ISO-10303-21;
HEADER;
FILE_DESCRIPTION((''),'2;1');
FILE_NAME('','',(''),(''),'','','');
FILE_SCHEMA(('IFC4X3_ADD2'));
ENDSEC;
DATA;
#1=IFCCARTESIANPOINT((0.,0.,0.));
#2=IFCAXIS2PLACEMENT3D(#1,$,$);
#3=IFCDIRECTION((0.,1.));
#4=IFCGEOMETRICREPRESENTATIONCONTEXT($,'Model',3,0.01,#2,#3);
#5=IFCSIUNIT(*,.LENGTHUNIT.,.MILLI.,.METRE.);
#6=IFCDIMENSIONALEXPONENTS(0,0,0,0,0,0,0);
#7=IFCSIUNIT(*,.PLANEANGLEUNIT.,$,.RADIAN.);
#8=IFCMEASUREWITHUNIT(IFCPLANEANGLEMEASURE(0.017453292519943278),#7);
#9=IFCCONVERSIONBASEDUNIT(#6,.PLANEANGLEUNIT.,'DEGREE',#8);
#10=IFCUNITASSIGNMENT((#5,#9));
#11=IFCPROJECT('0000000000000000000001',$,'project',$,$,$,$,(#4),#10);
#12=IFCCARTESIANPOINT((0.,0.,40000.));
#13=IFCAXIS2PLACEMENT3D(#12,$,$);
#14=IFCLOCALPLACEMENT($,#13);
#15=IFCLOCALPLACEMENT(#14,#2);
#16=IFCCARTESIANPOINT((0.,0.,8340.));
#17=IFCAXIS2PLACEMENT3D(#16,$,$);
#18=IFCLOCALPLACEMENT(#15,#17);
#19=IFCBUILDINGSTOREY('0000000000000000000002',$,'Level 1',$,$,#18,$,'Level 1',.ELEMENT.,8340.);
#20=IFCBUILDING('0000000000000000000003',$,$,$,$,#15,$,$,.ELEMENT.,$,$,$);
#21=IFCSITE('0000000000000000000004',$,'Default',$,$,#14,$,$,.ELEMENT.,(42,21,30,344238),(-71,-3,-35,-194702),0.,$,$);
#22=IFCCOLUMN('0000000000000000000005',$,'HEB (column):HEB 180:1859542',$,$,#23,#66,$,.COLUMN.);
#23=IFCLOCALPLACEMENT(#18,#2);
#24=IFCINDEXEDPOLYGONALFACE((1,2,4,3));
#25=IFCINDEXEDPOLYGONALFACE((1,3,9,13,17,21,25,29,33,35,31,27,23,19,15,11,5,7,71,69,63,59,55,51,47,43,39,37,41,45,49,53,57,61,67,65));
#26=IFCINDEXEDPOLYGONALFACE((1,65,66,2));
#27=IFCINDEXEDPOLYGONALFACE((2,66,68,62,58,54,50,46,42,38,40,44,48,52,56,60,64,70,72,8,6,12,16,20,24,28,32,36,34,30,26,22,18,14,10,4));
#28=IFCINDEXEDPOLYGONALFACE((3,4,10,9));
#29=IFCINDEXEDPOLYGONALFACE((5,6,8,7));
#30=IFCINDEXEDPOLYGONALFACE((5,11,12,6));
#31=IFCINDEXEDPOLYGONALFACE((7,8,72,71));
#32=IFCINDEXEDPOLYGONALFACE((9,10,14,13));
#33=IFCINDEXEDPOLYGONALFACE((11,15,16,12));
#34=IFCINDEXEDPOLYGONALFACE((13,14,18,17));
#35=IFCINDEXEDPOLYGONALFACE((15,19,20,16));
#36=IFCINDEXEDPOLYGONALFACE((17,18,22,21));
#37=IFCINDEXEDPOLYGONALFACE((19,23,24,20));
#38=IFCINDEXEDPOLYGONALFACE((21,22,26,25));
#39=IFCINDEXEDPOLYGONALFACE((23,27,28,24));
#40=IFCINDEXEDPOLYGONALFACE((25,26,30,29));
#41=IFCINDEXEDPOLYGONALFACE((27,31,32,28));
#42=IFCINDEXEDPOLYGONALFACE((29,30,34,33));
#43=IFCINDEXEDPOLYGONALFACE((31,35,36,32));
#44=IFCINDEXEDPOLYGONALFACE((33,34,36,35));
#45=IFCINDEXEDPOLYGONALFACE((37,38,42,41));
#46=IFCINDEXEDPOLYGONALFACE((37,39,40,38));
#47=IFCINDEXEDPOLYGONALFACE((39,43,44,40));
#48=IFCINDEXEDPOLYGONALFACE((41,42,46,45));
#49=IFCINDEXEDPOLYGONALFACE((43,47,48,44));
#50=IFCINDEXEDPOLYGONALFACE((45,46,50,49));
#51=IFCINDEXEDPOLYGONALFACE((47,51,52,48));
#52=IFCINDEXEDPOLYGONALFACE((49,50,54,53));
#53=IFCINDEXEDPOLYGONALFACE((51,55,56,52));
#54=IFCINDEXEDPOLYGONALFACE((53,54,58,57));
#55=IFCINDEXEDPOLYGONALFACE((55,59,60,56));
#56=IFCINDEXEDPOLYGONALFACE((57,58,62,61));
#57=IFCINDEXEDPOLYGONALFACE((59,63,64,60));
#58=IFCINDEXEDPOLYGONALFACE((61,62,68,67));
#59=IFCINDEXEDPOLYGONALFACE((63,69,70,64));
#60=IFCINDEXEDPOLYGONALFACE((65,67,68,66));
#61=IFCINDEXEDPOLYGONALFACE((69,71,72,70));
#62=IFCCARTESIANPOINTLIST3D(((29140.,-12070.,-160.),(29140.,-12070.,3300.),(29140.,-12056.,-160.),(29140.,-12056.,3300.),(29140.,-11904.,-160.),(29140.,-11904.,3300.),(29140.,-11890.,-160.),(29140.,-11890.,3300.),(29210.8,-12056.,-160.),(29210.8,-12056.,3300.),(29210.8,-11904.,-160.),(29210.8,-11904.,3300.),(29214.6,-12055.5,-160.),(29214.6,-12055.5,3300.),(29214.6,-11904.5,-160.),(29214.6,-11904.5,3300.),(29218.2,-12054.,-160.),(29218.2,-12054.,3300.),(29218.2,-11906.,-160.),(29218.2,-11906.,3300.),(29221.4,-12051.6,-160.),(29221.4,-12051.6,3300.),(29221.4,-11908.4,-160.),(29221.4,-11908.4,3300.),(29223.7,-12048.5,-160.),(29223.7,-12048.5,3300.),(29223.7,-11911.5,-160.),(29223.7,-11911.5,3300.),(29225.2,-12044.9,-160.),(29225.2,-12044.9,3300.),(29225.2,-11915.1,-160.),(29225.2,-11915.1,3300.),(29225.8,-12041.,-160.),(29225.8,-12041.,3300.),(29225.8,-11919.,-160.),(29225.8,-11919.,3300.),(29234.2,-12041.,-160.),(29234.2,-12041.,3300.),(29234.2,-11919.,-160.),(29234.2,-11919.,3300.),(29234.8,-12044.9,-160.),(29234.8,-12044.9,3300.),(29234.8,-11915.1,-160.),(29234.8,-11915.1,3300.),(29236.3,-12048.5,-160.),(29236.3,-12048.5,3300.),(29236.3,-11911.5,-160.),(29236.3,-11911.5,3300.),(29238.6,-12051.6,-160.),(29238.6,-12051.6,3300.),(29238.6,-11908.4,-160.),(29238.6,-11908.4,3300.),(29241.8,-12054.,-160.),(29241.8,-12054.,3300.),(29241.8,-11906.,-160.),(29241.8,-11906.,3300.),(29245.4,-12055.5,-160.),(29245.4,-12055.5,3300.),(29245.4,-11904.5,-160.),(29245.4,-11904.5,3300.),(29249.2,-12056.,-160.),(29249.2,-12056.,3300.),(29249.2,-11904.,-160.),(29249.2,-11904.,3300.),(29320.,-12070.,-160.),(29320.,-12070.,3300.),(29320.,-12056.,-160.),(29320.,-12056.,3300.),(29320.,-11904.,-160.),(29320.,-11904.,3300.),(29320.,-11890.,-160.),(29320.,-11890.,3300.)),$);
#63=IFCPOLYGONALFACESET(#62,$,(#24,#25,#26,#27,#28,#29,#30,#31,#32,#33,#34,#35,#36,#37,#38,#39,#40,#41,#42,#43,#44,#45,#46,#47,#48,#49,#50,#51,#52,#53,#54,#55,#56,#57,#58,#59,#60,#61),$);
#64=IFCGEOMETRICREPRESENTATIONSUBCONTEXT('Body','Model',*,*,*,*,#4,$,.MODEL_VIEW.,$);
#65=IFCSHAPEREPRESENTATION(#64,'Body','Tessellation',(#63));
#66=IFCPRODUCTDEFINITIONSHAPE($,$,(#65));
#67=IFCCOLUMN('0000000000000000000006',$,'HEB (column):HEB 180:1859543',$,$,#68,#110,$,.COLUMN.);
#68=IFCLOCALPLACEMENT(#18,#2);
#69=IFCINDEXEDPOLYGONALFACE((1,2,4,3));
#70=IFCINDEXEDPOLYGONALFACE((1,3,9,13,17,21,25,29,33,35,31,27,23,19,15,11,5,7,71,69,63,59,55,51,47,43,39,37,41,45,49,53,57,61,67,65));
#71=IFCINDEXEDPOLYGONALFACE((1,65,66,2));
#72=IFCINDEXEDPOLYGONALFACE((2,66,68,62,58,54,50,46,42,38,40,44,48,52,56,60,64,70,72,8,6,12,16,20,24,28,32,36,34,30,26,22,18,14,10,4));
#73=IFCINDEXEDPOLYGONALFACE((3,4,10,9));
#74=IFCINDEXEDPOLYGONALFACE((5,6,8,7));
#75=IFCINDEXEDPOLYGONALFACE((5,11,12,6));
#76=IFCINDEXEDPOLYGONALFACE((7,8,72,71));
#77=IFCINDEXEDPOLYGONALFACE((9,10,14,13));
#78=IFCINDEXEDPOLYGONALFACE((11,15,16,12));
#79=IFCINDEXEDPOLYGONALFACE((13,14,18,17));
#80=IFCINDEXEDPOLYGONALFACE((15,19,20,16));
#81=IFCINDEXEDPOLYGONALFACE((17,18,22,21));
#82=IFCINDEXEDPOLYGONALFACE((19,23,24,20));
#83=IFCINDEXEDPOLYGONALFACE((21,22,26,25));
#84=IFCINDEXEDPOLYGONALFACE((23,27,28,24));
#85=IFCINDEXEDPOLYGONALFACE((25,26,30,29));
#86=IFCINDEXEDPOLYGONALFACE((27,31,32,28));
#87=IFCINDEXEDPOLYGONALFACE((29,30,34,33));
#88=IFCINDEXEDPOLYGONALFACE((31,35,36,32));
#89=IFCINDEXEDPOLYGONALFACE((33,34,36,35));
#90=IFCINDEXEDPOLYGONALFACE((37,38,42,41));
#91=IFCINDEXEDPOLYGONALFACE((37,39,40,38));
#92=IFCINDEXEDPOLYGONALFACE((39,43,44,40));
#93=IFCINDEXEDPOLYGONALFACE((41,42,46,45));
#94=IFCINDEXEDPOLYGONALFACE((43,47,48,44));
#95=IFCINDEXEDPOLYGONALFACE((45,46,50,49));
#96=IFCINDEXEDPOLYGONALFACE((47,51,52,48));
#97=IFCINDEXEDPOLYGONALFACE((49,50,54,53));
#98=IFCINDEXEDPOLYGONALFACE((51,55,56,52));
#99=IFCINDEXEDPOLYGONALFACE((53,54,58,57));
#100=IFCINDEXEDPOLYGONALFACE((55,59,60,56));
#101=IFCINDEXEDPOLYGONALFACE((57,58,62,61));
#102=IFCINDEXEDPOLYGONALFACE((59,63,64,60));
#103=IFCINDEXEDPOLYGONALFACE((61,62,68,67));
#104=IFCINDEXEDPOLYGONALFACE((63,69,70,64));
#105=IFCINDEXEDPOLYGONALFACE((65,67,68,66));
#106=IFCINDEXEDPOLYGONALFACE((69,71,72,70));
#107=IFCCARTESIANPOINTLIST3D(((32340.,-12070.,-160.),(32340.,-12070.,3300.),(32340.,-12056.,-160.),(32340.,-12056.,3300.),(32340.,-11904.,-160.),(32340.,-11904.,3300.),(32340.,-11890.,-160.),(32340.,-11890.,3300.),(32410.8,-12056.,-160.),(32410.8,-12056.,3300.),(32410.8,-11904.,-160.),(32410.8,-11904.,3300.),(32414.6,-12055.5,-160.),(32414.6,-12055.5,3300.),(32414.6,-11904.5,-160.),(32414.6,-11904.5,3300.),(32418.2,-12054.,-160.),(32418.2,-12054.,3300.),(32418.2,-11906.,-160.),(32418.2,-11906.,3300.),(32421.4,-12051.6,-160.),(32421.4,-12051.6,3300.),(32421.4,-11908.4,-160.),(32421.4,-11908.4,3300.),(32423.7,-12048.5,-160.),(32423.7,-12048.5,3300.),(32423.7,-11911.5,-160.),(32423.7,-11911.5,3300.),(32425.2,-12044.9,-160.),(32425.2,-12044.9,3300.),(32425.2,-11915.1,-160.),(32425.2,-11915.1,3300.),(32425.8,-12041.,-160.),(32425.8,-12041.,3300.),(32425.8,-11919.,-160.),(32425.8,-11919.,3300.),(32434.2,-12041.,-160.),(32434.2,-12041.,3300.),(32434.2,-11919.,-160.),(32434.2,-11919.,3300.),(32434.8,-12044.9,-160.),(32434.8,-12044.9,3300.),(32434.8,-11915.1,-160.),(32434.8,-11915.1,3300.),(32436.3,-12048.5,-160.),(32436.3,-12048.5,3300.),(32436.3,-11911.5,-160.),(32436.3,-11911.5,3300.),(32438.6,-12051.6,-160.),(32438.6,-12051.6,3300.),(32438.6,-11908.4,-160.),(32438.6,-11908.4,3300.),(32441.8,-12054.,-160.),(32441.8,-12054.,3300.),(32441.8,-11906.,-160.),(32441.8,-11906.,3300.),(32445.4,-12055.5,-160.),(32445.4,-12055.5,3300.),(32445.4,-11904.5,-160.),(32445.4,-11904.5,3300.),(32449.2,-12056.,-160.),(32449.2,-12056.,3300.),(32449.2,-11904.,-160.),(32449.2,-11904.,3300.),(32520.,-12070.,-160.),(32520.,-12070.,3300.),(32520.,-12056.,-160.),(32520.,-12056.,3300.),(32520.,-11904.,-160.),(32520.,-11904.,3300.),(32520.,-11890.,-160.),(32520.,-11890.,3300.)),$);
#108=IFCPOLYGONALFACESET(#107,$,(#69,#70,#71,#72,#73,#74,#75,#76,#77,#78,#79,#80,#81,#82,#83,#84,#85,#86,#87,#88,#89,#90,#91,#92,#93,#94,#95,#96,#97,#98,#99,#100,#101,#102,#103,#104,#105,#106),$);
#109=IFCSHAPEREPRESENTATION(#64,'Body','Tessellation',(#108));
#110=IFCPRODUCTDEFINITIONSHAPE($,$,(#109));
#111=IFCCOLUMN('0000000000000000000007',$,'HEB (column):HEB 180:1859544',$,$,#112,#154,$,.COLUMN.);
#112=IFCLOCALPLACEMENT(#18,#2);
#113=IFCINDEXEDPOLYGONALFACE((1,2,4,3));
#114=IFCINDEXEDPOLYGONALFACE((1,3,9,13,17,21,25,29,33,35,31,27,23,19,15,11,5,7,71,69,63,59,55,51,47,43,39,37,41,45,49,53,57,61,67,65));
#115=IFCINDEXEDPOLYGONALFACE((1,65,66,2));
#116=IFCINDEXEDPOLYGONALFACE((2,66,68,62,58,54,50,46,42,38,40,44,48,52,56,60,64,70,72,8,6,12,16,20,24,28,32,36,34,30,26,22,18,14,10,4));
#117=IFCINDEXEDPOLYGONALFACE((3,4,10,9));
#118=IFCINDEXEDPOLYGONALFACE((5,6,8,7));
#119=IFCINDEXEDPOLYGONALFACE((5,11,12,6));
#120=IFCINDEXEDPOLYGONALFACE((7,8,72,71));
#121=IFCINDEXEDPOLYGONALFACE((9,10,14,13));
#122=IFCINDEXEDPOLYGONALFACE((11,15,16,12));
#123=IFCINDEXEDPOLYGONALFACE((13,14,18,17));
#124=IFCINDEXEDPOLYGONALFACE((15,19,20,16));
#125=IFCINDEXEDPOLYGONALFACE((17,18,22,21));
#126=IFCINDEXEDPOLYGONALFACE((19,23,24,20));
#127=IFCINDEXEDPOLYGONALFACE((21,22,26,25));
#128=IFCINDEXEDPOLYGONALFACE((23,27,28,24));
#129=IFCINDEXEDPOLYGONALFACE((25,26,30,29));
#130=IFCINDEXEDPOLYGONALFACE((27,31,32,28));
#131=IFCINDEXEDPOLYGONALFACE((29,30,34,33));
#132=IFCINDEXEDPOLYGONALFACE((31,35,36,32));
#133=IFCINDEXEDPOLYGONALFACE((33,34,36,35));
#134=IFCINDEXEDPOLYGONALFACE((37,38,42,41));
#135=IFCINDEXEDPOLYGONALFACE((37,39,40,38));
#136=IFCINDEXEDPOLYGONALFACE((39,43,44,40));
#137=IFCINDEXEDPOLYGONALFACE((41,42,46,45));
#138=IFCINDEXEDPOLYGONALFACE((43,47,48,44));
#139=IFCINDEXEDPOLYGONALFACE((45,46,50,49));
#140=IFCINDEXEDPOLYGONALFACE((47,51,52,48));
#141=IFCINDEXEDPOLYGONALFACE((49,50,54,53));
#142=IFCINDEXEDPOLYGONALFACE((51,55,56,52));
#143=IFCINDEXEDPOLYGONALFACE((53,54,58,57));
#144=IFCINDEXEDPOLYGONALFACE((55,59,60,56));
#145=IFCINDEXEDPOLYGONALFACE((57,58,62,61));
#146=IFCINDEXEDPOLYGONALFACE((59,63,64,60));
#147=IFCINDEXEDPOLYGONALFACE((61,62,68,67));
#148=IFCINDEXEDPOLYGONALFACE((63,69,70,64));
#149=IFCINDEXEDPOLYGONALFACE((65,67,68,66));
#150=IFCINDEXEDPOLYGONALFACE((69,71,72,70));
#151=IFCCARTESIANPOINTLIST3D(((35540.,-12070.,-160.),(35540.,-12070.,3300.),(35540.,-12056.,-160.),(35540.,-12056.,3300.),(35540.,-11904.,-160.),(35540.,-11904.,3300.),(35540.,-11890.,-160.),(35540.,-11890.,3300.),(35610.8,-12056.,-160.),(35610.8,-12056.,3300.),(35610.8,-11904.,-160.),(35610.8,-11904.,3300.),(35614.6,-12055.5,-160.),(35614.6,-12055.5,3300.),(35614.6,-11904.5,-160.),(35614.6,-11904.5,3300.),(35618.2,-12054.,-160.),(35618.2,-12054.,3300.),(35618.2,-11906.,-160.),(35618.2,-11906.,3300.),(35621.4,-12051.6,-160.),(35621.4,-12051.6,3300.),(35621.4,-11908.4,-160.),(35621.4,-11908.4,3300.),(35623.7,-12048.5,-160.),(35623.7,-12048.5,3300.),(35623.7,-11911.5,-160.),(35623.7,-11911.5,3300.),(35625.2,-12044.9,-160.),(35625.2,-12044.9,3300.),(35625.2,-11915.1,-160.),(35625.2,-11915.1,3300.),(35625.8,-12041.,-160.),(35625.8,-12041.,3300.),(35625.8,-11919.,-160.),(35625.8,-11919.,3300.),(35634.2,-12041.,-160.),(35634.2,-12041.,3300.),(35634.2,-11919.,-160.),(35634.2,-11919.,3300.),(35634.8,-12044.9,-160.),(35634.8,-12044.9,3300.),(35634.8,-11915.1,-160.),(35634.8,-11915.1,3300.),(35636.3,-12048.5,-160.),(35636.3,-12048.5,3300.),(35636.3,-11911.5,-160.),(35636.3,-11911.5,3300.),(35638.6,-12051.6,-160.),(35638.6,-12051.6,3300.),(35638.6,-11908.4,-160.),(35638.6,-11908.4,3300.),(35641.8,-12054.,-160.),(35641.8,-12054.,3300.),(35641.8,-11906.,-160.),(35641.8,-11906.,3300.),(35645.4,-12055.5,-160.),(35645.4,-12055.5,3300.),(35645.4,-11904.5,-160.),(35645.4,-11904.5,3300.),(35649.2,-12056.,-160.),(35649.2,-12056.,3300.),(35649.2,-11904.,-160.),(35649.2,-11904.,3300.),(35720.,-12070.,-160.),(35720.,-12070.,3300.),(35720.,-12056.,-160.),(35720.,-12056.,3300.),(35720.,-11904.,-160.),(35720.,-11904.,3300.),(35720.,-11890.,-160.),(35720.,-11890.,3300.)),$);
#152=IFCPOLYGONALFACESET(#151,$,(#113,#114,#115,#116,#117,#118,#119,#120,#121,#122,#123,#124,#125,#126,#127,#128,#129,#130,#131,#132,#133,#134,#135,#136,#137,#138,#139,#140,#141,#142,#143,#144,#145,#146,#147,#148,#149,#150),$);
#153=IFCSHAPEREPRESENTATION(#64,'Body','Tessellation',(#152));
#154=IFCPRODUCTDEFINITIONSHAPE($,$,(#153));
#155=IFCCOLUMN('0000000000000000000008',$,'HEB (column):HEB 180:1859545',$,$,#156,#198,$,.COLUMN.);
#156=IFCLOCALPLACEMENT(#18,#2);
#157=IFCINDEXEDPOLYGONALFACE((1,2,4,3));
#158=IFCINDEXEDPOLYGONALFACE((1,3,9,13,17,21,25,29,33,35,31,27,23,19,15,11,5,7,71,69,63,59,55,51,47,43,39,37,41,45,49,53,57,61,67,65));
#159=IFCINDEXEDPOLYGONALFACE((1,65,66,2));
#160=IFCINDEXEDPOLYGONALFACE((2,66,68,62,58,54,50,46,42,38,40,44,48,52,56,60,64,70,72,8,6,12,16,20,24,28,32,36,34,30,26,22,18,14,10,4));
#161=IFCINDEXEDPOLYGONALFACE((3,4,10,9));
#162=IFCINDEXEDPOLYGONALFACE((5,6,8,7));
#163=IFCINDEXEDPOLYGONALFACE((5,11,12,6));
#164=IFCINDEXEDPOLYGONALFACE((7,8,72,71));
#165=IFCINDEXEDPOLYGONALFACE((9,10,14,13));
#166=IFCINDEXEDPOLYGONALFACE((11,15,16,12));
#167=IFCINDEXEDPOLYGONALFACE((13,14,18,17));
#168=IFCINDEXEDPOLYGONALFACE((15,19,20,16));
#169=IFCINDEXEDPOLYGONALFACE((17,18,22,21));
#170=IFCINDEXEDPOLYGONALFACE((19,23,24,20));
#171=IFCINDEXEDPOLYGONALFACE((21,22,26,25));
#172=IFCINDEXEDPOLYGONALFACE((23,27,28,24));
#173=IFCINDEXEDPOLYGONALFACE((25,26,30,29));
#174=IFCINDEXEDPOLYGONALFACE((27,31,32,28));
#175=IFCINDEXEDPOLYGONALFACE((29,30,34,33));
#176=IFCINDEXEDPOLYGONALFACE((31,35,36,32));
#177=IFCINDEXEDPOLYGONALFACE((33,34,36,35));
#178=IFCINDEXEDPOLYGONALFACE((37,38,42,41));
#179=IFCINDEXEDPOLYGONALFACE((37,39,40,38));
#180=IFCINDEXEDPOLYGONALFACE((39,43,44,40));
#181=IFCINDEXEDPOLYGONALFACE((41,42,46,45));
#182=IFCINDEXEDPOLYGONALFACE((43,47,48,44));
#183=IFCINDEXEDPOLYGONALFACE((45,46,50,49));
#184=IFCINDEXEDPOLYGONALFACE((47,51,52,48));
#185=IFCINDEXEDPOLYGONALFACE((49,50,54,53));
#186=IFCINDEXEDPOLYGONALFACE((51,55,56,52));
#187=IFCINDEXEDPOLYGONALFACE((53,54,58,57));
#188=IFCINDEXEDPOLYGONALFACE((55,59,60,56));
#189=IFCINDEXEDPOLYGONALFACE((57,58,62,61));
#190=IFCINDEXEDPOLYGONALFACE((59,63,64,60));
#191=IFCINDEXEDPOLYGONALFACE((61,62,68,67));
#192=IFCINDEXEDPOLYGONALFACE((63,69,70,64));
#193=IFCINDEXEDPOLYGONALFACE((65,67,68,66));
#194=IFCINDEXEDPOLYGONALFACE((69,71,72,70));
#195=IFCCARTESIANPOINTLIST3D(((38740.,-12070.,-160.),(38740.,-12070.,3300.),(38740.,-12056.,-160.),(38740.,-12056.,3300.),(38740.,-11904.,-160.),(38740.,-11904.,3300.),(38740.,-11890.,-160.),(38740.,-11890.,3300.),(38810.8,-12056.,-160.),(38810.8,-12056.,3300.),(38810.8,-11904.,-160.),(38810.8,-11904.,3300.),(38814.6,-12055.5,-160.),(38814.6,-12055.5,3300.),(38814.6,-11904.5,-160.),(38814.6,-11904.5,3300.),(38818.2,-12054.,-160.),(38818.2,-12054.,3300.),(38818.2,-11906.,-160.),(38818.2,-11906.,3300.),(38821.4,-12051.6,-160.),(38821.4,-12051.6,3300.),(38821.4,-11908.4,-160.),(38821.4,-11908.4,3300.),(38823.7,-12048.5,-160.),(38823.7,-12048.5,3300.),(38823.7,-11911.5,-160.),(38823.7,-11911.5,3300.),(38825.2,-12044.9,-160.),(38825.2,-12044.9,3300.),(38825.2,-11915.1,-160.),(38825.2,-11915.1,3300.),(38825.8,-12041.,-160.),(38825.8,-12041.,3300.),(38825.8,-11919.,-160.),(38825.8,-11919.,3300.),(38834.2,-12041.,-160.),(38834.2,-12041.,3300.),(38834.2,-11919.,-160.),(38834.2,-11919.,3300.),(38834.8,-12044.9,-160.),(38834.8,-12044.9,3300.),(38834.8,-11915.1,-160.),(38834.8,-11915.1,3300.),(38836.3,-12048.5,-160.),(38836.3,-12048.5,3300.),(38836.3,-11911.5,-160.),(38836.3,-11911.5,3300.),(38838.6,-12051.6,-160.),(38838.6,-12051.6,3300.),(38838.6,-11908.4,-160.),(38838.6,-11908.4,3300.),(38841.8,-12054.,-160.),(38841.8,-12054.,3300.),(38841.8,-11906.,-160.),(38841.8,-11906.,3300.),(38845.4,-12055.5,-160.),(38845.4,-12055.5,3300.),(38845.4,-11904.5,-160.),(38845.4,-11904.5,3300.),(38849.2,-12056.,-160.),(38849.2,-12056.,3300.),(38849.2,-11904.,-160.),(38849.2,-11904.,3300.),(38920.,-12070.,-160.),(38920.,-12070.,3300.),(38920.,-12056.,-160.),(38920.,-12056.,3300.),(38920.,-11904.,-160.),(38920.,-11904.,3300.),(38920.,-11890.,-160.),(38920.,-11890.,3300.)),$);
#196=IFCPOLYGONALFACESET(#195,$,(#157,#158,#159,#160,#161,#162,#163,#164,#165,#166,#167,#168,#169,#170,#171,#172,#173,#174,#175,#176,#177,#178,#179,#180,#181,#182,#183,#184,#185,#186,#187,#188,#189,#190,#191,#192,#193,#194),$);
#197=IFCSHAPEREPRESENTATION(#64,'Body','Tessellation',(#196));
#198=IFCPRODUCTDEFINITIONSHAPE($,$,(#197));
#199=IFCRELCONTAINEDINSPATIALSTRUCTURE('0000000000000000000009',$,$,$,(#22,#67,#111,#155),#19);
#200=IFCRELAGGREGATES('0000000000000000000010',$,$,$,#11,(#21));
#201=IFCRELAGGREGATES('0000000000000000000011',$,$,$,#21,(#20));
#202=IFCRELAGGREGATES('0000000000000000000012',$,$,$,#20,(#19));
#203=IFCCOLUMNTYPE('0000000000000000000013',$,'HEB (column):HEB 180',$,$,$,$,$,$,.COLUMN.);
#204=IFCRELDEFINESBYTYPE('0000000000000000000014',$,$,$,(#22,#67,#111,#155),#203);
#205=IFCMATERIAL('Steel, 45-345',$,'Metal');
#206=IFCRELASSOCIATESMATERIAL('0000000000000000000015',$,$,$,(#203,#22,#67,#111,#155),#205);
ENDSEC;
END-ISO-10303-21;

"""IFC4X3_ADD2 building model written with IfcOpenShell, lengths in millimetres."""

from ifc_helpers import new_model, entity, si_unit, converted_unit, direction, frame, origin, origin_2d_with_axis, place, context, subcontext, project, spatial, i_section, extrude, source, transform, mapped, material, material_profile, profile_set, profile_usage, type_object, type_shapes, element, save


model = new_model("IFC4X3_ADD2")

# Units and contexts
model_context = context("Model", 3, precision=0.01, world=origin(), true_north=direction((0.0, 1.0)))
body_context = subcontext(model_context, "Body", "Model", "MODEL_VIEW")
ifc_project = project(units=[si_unit("LENGTHUNIT", "METRE", prefix="MILLI"), converted_unit("PLANEANGLEUNIT", "DEGREE", entity("IfcPlaneAngleMeasure", 0.017453292519943278), si_unit("PLANEANGLEUNIT", "RADIAN"), dimensions=[0, 0, 0, 0, 0, 0, 0])], contexts=[model_context])

# Site, building, storey
site_placement = place(None, frame((0.0, 0.0, 40000.0)))
site = spatial("IfcSite", under=ifc_project, at=site_placement, Name="Default", CompositionType="ELEMENT", RefLatitude=(42, 21, 30, 344238), RefLongitude=(-71, -3, -35, -194702), RefElevation=0.0)
building_placement = place(site_placement, origin())
building = spatial("IfcBuilding", under=site, at=building_placement, CompositionType="ELEMENT")
storey_placement = place(building_placement, frame((0.0, 0.0, 8340.0)))
storey = spatial("IfcBuildingStorey", under=building, at=storey_placement, Name="Level 1", LongName="Level 1", CompositionType="ELEMENT", Elevation=8340.0)

# Columns
ifc_material = material(Name="Steel, 45-345", Category="Metal")
ifc_material_profile_1 = material_profile(ifc_material, i_section(OverallWidth=180.0, OverallDepth=180.0, WebThickness=8.5, FlangeThickness=14.0, FilletRadius=15.0, at=origin_2d_with_axis()), Name="HEB 180")
ifc_profile_set_1 = profile_set([ifc_material_profile_1], Name="HEB 180")
ifc_profile_usage_1 = profile_usage(ifc_profile_set_1)
column_type_1 = type_object("IfcColumnType", Name="HEB (column):HEB 180", PredefinedType="COLUMN", material=ifc_profile_set_1)
shared_shape_1 = source(origin(), body_context, "Body", "SweptSolid", [
    extrude(i_section(OverallWidth=180.0, OverallDepth=180.0, WebThickness=8.5, FlangeThickness=14.0, FilletRadius=15.0, at=origin_2d_with_axis()), frame((0.0, 0.0, 8180.0), z_axis=(0.0, 0.0, 1.0), x_axis=(-1.0, 0.0, 0.0)), (0.0, 0.0, 1.0), 3460.0),
])
type_shapes(column_type_1, [shared_shape_1])
for number, where, name in (
    (1, (29230.0, -11980.0, -8340.0), "HEB (column):HEB 180:1859542"),
    (2, (32430.0, -11980.0, -8340.0), "HEB (column):HEB 180:1859543"),
    (3, (35630.0, -11980.0, -8340.0), "HEB (column):HEB 180:1859544"),
    (4, (38830.0, -11980.0, -8340.0), "HEB (column):HEB 180:1859545"),
):
    element("IfcColumn", number, at=place(storey_placement, frame(where)), inside=storey, type_object=column_type_1, material=ifc_profile_usage_1, Name=name, PredefinedType="COLUMN", context=body_context, shape_type="MappedRepresentation", body=[
        mapped(shared_shape_1, transform((0.0, 0.0, 0.0), scale=1.0)),
    ])

save(model, "model.ifc")
